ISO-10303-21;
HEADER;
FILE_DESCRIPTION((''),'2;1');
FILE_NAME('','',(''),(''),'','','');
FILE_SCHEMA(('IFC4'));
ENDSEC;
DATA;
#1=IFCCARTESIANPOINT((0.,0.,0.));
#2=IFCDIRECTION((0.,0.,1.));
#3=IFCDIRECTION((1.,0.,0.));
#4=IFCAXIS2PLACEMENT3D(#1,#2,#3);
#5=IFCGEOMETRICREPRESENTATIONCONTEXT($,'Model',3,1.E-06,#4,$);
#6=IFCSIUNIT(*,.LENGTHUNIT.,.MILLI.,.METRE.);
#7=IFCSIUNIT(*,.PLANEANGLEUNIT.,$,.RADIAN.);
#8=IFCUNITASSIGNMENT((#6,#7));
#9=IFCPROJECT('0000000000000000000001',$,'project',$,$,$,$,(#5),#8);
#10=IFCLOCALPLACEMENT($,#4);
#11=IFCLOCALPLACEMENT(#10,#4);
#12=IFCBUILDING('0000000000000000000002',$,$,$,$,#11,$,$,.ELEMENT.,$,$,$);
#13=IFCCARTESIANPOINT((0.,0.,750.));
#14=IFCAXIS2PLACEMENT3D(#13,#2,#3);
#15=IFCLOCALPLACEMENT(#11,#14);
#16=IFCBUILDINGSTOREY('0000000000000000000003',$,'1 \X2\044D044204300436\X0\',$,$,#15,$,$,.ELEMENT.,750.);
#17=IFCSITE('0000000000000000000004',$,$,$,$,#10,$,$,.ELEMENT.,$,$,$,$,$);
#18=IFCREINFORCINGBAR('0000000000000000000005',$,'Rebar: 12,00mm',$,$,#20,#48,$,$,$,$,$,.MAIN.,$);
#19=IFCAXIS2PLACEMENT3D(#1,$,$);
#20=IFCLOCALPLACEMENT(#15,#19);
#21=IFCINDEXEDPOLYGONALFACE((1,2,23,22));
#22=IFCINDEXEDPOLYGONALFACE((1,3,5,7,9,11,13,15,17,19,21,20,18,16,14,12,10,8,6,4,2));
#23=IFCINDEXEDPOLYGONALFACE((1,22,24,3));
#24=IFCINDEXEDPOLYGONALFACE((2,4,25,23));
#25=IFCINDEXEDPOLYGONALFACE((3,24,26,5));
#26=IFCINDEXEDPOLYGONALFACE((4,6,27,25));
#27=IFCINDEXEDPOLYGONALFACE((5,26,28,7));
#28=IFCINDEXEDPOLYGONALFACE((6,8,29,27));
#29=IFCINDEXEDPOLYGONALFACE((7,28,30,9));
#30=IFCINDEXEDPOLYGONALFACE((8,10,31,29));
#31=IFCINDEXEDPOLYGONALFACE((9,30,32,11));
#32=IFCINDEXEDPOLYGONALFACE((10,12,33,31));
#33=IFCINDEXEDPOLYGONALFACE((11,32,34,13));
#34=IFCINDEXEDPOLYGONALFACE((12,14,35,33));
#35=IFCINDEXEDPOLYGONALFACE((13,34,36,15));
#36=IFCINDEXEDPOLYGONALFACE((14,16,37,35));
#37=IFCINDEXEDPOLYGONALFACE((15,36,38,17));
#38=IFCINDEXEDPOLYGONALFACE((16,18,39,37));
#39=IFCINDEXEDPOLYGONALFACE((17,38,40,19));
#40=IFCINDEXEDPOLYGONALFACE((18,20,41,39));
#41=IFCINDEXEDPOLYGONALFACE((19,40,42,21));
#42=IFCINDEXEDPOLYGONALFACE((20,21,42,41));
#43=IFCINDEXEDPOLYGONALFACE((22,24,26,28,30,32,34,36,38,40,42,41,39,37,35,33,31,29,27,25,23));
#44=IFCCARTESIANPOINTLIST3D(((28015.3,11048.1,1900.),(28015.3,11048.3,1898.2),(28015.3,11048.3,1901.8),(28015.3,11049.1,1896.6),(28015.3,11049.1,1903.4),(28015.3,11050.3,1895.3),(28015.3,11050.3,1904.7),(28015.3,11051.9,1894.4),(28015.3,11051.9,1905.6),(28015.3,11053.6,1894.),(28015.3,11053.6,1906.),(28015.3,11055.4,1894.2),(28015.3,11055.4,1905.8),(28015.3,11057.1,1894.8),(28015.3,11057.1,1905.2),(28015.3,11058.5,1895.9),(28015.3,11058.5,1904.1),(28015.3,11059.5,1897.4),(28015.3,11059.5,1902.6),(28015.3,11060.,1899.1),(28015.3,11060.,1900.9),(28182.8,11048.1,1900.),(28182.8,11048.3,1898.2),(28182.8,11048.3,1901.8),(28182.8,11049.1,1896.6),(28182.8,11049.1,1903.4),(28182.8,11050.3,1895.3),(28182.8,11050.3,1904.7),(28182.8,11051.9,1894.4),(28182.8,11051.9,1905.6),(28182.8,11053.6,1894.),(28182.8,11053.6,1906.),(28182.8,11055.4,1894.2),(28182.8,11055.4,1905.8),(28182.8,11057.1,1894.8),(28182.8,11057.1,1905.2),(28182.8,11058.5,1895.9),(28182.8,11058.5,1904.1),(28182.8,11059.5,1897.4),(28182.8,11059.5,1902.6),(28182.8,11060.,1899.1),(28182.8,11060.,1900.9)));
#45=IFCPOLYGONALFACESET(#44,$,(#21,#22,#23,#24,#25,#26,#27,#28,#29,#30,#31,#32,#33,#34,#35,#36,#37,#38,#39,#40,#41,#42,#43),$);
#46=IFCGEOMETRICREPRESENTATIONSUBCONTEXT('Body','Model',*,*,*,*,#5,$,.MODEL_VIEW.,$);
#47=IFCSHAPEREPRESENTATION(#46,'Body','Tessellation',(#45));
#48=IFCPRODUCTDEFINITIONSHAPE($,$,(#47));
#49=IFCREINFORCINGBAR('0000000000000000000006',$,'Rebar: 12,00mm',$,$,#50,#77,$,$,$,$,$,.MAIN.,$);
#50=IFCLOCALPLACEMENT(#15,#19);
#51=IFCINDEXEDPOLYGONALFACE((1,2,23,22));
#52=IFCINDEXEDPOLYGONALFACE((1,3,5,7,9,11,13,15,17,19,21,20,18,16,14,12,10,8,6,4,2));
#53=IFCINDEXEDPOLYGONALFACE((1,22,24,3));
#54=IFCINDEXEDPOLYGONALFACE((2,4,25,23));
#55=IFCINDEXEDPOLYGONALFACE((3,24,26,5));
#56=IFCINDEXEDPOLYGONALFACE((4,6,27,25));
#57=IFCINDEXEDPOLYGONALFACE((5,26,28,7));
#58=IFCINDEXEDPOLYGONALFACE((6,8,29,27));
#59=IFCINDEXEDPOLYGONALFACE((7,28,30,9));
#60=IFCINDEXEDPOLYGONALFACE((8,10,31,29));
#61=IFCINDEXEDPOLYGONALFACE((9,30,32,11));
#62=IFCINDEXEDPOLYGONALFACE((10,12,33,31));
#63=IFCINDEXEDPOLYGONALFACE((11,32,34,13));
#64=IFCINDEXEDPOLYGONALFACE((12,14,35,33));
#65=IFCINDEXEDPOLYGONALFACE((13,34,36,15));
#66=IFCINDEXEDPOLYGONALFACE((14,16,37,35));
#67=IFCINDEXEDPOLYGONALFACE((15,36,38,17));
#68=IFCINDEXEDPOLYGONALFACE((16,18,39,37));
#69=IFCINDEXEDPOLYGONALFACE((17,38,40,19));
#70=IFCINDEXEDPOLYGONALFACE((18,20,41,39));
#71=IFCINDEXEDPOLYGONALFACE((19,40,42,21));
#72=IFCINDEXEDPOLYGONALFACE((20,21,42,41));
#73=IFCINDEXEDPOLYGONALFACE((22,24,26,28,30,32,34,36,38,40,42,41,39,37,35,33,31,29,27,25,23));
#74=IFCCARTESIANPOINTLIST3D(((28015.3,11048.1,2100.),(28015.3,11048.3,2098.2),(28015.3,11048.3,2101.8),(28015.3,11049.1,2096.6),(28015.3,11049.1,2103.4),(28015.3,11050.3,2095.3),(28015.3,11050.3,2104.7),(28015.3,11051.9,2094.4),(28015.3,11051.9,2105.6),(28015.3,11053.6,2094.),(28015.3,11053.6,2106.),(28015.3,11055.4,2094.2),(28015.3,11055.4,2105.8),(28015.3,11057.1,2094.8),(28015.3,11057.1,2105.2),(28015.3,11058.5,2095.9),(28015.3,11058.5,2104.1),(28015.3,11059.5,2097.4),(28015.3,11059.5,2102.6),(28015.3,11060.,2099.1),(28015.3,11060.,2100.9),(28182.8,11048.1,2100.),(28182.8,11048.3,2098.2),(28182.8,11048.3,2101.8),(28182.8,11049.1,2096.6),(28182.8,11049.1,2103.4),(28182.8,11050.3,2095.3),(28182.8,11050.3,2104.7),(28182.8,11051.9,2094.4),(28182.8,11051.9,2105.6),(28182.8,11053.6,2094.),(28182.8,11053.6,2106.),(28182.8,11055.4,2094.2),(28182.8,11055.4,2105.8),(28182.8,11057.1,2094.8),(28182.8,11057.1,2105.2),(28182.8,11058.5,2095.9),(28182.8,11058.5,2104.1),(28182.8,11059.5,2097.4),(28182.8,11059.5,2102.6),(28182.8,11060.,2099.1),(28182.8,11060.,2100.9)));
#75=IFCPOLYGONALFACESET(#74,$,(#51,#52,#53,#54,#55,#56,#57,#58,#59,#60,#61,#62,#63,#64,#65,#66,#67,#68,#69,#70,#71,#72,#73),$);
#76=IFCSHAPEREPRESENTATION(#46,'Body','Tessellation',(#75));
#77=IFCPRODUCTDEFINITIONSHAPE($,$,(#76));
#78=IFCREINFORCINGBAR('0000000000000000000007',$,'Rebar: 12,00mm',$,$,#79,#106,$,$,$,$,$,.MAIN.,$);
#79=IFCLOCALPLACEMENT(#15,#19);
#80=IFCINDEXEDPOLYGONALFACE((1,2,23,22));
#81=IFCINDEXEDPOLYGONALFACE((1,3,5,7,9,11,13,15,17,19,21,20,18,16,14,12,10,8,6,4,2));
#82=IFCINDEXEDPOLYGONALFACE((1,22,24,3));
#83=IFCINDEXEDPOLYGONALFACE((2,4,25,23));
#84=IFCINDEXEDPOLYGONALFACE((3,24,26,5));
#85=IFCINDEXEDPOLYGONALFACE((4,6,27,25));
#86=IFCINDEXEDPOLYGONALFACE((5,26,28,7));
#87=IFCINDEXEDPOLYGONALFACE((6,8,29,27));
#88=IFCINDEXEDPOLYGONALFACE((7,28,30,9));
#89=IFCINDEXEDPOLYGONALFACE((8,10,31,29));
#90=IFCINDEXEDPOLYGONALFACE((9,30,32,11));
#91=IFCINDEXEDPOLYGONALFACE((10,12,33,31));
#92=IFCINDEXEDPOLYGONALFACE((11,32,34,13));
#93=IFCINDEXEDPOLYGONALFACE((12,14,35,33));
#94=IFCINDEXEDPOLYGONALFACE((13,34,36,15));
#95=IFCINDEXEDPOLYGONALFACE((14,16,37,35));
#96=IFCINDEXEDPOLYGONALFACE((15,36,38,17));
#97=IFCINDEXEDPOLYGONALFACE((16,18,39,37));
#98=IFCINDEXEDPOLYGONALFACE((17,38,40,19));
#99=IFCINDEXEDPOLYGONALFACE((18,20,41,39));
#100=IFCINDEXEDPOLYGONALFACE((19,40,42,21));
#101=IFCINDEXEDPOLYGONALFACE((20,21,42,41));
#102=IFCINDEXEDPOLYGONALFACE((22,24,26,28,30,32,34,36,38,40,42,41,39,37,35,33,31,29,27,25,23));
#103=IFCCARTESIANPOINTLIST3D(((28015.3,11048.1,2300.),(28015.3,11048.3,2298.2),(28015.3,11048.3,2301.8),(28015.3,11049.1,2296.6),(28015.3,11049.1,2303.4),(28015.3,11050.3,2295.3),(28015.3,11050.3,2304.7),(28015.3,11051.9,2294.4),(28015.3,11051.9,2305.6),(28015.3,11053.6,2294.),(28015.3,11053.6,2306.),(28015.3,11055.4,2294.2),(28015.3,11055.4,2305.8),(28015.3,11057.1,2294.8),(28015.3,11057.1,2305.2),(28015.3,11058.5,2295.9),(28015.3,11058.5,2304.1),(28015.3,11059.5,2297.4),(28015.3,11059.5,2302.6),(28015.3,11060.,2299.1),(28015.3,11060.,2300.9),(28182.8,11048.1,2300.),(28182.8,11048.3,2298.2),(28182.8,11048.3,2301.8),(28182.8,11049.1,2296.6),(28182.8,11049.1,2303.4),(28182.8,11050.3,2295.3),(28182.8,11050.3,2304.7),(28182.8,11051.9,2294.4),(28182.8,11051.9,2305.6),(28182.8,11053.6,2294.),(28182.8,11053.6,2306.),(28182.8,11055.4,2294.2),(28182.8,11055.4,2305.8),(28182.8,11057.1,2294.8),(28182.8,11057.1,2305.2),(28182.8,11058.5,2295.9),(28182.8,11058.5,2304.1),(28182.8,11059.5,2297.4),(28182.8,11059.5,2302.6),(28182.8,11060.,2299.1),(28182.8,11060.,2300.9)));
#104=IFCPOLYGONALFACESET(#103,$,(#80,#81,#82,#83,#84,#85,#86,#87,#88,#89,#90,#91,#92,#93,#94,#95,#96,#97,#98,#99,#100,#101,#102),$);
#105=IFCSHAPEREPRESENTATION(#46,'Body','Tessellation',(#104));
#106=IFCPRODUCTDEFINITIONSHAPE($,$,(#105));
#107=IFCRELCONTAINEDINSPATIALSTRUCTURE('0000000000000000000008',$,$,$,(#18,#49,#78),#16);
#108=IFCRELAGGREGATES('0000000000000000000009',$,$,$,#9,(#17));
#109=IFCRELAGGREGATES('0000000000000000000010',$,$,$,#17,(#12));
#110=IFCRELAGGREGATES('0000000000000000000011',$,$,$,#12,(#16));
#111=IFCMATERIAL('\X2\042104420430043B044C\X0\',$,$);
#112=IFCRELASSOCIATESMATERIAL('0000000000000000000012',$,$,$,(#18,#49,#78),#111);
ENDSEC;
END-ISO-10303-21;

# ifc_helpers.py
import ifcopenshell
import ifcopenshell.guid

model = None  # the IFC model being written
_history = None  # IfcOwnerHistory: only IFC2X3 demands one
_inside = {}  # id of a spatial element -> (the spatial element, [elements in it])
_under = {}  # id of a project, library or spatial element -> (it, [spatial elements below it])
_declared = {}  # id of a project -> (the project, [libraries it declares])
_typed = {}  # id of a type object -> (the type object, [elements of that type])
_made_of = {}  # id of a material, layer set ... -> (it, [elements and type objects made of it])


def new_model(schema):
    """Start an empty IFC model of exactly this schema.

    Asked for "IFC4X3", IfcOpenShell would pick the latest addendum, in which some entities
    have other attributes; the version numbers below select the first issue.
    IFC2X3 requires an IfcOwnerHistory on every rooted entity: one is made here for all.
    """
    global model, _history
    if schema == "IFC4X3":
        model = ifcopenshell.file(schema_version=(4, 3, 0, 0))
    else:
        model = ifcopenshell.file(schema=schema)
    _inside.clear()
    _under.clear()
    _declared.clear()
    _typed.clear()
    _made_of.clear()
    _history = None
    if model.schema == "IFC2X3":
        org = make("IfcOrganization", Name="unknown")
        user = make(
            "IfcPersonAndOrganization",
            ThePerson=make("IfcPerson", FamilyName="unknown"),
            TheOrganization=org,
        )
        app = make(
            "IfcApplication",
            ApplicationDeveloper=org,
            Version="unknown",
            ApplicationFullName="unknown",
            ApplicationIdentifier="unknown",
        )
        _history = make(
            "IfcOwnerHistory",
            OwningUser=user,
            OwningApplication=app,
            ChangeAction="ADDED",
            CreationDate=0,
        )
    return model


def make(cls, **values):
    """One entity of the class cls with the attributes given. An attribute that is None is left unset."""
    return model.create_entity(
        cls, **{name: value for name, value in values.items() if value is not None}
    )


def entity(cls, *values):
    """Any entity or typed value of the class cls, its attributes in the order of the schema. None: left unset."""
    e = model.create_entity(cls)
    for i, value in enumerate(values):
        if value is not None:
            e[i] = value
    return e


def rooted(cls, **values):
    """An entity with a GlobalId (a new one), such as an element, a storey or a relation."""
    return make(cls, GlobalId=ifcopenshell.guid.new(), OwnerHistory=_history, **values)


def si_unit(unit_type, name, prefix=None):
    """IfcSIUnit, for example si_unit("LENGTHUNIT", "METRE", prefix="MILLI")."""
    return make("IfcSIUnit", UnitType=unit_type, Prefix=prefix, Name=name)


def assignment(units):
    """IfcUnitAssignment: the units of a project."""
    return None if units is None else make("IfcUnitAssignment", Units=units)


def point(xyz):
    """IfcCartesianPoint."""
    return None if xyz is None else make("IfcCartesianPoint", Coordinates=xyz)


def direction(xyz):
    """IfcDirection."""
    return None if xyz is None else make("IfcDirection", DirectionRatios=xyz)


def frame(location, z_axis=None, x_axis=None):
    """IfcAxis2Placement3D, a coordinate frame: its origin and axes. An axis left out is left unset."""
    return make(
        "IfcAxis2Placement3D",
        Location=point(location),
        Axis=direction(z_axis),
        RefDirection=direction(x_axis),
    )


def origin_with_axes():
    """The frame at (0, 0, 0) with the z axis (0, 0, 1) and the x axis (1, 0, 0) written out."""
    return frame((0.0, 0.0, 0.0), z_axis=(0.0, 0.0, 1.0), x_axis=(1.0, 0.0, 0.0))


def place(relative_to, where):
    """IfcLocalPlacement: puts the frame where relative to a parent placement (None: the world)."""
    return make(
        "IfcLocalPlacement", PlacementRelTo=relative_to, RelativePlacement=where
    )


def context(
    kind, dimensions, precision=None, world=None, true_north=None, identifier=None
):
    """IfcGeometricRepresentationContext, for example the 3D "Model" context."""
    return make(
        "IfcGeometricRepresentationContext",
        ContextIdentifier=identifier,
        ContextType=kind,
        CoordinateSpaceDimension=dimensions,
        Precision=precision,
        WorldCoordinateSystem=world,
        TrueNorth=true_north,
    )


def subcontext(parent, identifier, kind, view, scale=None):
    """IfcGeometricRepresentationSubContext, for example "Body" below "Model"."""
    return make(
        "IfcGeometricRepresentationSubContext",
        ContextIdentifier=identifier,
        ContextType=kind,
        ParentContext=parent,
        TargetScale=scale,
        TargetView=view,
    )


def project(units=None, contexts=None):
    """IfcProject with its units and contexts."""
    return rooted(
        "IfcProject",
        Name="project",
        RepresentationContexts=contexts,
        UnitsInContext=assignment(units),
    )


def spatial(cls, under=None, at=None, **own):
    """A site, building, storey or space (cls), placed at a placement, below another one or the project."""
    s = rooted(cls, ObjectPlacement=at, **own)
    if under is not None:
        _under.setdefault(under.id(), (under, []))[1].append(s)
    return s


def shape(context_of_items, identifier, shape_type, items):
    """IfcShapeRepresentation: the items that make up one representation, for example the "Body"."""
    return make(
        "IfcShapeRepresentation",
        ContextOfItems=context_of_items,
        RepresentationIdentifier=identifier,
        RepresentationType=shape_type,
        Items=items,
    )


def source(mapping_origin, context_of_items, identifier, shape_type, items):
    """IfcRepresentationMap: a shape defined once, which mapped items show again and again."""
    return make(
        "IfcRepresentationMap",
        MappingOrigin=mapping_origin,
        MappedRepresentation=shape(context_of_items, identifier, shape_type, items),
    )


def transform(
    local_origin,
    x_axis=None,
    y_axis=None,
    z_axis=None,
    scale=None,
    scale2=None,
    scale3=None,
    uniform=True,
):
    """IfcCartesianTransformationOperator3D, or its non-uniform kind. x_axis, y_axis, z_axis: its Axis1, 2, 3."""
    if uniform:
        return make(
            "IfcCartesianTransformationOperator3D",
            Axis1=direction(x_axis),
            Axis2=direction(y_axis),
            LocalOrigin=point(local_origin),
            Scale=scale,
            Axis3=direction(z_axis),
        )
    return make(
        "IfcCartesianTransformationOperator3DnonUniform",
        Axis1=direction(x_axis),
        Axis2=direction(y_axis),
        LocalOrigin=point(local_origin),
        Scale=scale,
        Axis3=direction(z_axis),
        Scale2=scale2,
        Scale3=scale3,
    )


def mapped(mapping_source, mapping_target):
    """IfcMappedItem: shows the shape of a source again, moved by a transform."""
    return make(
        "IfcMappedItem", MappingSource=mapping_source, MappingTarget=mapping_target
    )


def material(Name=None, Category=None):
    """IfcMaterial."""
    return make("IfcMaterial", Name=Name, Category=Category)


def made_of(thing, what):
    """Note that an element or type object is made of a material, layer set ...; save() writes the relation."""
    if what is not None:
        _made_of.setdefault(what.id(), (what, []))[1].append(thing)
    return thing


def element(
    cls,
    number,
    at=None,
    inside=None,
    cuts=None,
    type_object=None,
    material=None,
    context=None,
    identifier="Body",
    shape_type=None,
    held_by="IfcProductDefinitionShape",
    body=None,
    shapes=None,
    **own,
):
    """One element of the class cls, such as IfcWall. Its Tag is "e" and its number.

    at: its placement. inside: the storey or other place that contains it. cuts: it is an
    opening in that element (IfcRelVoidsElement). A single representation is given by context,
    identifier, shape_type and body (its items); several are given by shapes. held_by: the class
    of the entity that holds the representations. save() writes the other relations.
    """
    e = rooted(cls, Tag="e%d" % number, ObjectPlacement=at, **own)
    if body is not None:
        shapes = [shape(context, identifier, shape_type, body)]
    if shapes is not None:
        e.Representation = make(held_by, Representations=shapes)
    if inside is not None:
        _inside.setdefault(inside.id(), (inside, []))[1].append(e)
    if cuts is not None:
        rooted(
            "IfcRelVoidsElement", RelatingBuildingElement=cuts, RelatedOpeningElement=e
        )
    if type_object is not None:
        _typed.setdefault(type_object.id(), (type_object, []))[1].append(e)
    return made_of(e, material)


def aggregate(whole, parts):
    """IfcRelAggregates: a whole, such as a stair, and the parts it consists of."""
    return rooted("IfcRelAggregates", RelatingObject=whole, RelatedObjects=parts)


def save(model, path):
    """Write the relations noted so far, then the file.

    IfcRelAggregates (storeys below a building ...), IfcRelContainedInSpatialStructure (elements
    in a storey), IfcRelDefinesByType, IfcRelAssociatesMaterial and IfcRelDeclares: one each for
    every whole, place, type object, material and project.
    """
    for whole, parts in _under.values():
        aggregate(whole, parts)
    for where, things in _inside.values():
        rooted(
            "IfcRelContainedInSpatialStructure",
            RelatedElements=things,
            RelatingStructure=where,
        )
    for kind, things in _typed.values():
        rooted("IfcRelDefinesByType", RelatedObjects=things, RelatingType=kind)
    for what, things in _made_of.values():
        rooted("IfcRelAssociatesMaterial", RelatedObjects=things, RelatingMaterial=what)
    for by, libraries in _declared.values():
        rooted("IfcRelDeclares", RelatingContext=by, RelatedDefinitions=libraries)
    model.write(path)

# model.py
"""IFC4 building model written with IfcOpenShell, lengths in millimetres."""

from ifc_helpers import new_model, entity, si_unit, frame, origin_with_axes, place, context, subcontext, project, spatial, source, transform, mapped, material, element, save


model = new_model("IFC4")

# Units and contexts
model_context = context("Model", 3, precision=1e-06, world=origin_with_axes())
body_context = subcontext(model_context, "Body", "Model", "MODEL_VIEW")
ifc_project = project(units=[si_unit("LENGTHUNIT", "METRE", prefix="MILLI"), si_unit("PLANEANGLEUNIT", "RADIAN")], contexts=[model_context])

# Site, building, storey
site_placement = place(None, origin_with_axes())
site = spatial("IfcSite", under=ifc_project, at=site_placement, CompositionType="ELEMENT")
building_placement = place(site_placement, origin_with_axes())
building = spatial("IfcBuilding", under=site, at=building_placement, CompositionType="ELEMENT")
storey_placement = place(building_placement, frame((0.0, 0.0, 750.0), z_axis=(0.0, 0.0, 1.0), x_axis=(1.0, 0.0, 0.0)))
storey = spatial("IfcBuildingStorey", under=building, at=storey_placement, Name="1 этаж", CompositionType="ELEMENT", Elevation=750.0)

# Reinforcing bars
ifc_material = material(Name="Сталь")
shared_shape_1 = source(origin_with_axes(), body_context, "Body", "AdvancedSweptSolid", [
    entity("IfcSweptDiskSolid", entity("IfcIndexedPolyCurve", entity("IfcCartesianPointList3D", [[0.0, 0.0, 0.0], [167.5, 0.0, 0.0]]), [entity("IfcLineIndex", [1, 2])]), 6.0),
])
reinforcing_bar_1_placement = place(storey_placement, origin_with_axes())
element("IfcReinforcingBar", 1, at=reinforcing_bar_1_placement, inside=storey, material=ifc_material, Name="Rebar: 12,00mm", PredefinedType="MAIN", context=body_context, shape_type="MappedRepresentation", body=[
    mapped(shared_shape_1, transform((28182.8, 11054.1, 1900.0), x_axis=(-1.0, 0.0, 0.0), y_axis=(0.0, -1.0, 0.0), z_axis=(0.0, 0.0, 1.0), scale=1.0)),
])
reinforcing_bar_2_placement = place(storey_placement, origin_with_axes())
element("IfcReinforcingBar", 2, at=reinforcing_bar_2_placement, inside=storey, material=ifc_material, Name="Rebar: 12,00mm", PredefinedType="MAIN", context=body_context, shape_type="MappedRepresentation", body=[
    mapped(shared_shape_1, transform((28182.8, 11054.1, 2100.0), x_axis=(-1.0, 0.0, 0.0), y_axis=(0.0, -1.0, 0.0), z_axis=(0.0, 0.0, 1.0), scale=1.0)),
])
reinforcing_bar_3_placement = place(storey_placement, origin_with_axes())
element("IfcReinforcingBar", 3, at=reinforcing_bar_3_placement, inside=storey, material=ifc_material, Name="Rebar: 12,00mm", PredefinedType="MAIN", context=body_context, shape_type="MappedRepresentation", body=[
    mapped(shared_shape_1, transform((28182.8, 11054.1, 2300.0), x_axis=(-1.0, 0.0, 0.0), y_axis=(0.0, -1.0, 0.0), z_axis=(0.0, 0.0, 1.0), scale=1.0)),
])

save(model, "model.ifc")
